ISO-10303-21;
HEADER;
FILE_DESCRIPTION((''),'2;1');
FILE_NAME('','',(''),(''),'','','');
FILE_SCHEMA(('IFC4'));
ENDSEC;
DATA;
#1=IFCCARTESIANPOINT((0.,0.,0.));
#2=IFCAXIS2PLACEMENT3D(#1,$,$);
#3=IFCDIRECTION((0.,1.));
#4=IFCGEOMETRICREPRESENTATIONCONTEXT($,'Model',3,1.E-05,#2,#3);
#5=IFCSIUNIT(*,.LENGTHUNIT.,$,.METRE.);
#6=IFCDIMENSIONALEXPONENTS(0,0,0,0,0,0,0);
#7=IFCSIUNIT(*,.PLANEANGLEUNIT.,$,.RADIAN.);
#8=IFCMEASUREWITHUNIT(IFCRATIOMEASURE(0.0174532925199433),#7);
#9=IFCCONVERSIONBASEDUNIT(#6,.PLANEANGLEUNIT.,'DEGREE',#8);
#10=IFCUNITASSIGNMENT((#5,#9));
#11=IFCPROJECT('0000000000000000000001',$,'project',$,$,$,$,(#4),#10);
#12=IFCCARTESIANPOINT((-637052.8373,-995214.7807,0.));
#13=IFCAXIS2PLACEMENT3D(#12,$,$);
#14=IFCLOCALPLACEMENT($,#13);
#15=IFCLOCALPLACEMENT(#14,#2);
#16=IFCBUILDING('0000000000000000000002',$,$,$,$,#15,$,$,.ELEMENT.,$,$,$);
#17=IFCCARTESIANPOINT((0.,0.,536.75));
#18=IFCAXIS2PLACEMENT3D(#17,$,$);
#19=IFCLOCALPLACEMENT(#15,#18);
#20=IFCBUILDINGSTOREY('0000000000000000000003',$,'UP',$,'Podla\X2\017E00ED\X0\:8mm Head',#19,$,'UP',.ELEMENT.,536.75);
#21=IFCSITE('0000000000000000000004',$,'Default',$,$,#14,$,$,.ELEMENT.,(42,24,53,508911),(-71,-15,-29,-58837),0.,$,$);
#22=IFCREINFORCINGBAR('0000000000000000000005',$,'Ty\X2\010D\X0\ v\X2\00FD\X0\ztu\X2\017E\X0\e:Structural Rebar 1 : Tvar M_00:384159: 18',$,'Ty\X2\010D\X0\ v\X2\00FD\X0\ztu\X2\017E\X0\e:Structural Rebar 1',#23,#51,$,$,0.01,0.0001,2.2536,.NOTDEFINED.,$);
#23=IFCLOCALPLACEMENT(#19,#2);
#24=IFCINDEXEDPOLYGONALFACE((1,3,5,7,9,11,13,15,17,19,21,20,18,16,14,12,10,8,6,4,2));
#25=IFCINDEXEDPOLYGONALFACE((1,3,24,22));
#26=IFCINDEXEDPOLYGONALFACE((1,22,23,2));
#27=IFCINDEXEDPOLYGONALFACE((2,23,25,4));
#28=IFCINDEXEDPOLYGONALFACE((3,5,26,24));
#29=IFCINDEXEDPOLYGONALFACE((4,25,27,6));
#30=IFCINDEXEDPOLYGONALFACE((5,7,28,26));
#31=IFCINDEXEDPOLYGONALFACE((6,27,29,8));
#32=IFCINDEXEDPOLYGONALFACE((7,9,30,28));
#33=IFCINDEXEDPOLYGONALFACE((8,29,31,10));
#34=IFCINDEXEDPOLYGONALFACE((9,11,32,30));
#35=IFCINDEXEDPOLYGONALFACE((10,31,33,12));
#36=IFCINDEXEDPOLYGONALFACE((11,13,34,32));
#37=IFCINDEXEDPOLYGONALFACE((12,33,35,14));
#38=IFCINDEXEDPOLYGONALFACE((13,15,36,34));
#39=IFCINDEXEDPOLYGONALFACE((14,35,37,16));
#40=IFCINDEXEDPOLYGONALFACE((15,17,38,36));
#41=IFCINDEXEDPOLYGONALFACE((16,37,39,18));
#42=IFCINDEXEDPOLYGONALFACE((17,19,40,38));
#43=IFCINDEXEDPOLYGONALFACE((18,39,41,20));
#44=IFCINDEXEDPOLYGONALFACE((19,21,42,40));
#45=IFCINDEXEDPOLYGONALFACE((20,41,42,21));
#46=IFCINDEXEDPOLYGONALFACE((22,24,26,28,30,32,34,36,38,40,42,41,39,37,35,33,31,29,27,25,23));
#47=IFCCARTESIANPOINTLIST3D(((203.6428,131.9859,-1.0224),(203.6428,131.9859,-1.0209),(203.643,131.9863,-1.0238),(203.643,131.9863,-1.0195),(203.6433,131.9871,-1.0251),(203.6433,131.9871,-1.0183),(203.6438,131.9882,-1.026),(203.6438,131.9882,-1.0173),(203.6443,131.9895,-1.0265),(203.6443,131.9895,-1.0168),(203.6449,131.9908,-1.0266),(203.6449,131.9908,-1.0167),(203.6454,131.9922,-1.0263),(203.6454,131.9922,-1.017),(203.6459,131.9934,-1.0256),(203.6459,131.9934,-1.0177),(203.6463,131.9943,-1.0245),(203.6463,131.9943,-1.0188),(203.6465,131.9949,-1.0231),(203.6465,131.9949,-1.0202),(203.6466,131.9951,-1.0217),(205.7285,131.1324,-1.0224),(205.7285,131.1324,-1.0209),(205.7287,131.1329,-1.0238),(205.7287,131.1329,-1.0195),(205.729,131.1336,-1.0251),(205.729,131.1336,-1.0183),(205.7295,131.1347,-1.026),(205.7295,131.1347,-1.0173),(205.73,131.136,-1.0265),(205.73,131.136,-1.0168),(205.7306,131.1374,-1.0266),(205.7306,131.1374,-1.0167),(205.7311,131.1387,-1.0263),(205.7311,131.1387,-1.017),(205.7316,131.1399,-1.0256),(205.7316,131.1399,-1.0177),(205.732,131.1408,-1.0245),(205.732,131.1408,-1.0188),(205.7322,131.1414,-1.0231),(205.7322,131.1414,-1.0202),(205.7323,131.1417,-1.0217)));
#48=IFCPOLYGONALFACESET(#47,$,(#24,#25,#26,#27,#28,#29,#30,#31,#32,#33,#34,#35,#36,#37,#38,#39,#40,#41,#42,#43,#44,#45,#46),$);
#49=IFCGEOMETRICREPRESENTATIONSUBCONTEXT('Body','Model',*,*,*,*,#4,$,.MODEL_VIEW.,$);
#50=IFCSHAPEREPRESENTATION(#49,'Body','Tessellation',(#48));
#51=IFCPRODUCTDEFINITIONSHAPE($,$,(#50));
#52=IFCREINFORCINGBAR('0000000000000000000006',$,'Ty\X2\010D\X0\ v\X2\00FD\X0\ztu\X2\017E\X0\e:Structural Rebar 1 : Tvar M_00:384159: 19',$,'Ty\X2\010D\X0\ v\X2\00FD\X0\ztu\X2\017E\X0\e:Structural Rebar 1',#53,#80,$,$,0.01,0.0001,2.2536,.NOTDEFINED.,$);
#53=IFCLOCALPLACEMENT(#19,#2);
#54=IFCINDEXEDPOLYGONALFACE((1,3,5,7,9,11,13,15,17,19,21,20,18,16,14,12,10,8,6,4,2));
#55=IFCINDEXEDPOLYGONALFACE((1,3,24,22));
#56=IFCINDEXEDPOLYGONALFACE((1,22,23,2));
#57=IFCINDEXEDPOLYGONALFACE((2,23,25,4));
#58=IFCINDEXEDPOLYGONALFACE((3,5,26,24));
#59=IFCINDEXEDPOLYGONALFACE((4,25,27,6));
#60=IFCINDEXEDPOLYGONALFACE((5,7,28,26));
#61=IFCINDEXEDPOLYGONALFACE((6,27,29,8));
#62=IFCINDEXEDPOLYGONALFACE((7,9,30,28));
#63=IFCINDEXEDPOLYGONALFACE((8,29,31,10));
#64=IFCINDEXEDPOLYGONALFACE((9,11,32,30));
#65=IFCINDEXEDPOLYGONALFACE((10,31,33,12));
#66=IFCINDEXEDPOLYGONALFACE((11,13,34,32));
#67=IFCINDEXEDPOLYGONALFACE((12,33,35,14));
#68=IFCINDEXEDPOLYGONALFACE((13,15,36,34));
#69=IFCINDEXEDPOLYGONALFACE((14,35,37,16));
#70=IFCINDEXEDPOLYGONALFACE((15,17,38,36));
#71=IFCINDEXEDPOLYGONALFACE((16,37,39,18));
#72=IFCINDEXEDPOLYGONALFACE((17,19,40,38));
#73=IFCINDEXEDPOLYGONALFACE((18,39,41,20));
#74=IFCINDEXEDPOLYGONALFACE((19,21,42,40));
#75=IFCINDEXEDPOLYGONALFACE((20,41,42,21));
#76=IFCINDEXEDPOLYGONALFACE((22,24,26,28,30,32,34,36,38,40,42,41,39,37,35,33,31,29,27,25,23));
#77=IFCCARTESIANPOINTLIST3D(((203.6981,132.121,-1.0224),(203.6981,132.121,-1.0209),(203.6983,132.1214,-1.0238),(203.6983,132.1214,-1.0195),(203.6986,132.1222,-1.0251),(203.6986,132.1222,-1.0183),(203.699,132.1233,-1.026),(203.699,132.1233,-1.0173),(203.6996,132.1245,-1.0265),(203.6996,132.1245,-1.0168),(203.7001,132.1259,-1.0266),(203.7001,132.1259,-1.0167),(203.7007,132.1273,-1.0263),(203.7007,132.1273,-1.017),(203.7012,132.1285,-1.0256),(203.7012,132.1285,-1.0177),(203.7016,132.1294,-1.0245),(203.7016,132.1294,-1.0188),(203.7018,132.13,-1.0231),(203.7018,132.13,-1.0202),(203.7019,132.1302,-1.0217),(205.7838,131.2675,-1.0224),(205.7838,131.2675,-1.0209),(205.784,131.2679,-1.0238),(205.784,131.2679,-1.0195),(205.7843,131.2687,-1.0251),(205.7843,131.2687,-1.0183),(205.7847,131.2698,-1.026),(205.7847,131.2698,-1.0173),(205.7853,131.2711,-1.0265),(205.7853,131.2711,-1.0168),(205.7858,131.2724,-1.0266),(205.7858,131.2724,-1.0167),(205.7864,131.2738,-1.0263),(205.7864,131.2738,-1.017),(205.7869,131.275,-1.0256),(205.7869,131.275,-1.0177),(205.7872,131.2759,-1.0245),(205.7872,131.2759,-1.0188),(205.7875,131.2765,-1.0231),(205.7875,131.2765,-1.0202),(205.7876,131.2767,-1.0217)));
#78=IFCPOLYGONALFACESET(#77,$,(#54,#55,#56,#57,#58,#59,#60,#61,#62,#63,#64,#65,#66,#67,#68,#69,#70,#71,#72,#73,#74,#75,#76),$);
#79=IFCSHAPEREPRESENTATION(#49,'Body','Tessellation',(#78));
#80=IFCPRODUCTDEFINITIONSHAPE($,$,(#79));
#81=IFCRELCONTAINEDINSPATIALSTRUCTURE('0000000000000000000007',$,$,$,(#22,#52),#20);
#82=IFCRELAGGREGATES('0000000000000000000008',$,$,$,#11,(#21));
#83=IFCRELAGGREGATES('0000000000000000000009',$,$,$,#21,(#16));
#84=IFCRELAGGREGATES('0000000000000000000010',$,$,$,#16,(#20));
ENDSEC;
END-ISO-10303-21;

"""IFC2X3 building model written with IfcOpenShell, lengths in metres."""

from ifc_helpers import new_model, entity, si_unit, converted_unit, direction, frame, origin, place, context, subcontext, project, spatial, element, save


model = new_model("IFC2X3")

# Units and contexts
model_context = context("Model", 3, precision=1e-05, world=origin(), true_north=direction((0.0, 1.0)))
body_context = subcontext(model_context, "Body", "Model", "MODEL_VIEW")
ifc_project = project(units=[si_unit("LENGTHUNIT", "METRE"), converted_unit("PLANEANGLEUNIT", "DEGREE", entity("IfcRatioMeasure", 0.0174532925199433), si_unit("PLANEANGLEUNIT", "RADIAN"), dimensions=[0, 0, 0, 0, 0, 0, 0])], contexts=[model_context])

# Site, building, storey
site_placement = place(None, frame((-637052.8373, -995214.7807, 0.0)))
site = spatial("IfcSite", under=ifc_project, at=site_placement, Name="Default", CompositionType="ELEMENT", RefLatitude=(42, 24, 53, 508911), RefLongitude=(-71, -15, -29, -58837), RefElevation=0.0)
building_placement = place(site_placement, origin())
building = spatial("IfcBuilding", under=site, at=building_placement, CompositionType="ELEMENT")
storey_placement = place(building_placement, frame((0.0, 0.0, 536.75)))
storey = spatial("IfcBuildingStorey", under=building, at=storey_placement, Name="UP", ObjectType="Podlaží:8mm Head", LongName="UP", CompositionType="ELEMENT", Elevation=536.75)

# Reinforcing bars
reinforcing_bar_1_placement = place(storey_placement, origin())
element("IfcReinforcingBar", 1, at=reinforcing_bar_1_placement, inside=storey, Name="Tyč výztuže:Structural Rebar 1 : Tvar M_00:384159: 18", ObjectType="Tyč výztuže:Structural Rebar 1", BarLength=2.2536, BarRole="NOTDEFINED", CrossSectionArea=0.0001, NominalDiameter=0.01, context=body_context, shape_type="AdvancedSweptSolid", body=[
    entity("IfcSweptDiskSolid", entity("IfcCompositeCurve", [entity("IfcCompositeCurveSegment", "CONTINUOUS", True, entity("IfcPolyline", [entity("IfcCartesianPoint", [-205.7304, -131.137, 1.0217]), entity("IfcCartesianPoint", [-203.6447, -131.9905, 1.0217])]))], False), 0.005, None, 0.0, 1.0),
])
reinforcing_bar_2_placement = place(storey_placement, origin())
element("IfcReinforcingBar", 2, at=reinforcing_bar_2_placement, inside=storey, Name="Tyč výztuže:Structural Rebar 1 : Tvar M_00:384159: 19", ObjectType="Tyč výztuže:Structural Rebar 1", BarLength=2.2536, BarRole="NOTDEFINED", CrossSectionArea=0.0001, NominalDiameter=0.01, context=body_context, shape_type="AdvancedSweptSolid", body=[
    entity("IfcSweptDiskSolid", entity("IfcCompositeCurve", [entity("IfcCompositeCurveSegment", "CONTINUOUS", True, entity("IfcPolyline", [entity("IfcCartesianPoint", [-205.7857, -131.2721, 1.0217]), entity("IfcCartesianPoint", [-203.7, -132.1256, 1.0217])]))], False), 0.005, None, 0.0, 1.0),
])

save(model, "model.ifc")
